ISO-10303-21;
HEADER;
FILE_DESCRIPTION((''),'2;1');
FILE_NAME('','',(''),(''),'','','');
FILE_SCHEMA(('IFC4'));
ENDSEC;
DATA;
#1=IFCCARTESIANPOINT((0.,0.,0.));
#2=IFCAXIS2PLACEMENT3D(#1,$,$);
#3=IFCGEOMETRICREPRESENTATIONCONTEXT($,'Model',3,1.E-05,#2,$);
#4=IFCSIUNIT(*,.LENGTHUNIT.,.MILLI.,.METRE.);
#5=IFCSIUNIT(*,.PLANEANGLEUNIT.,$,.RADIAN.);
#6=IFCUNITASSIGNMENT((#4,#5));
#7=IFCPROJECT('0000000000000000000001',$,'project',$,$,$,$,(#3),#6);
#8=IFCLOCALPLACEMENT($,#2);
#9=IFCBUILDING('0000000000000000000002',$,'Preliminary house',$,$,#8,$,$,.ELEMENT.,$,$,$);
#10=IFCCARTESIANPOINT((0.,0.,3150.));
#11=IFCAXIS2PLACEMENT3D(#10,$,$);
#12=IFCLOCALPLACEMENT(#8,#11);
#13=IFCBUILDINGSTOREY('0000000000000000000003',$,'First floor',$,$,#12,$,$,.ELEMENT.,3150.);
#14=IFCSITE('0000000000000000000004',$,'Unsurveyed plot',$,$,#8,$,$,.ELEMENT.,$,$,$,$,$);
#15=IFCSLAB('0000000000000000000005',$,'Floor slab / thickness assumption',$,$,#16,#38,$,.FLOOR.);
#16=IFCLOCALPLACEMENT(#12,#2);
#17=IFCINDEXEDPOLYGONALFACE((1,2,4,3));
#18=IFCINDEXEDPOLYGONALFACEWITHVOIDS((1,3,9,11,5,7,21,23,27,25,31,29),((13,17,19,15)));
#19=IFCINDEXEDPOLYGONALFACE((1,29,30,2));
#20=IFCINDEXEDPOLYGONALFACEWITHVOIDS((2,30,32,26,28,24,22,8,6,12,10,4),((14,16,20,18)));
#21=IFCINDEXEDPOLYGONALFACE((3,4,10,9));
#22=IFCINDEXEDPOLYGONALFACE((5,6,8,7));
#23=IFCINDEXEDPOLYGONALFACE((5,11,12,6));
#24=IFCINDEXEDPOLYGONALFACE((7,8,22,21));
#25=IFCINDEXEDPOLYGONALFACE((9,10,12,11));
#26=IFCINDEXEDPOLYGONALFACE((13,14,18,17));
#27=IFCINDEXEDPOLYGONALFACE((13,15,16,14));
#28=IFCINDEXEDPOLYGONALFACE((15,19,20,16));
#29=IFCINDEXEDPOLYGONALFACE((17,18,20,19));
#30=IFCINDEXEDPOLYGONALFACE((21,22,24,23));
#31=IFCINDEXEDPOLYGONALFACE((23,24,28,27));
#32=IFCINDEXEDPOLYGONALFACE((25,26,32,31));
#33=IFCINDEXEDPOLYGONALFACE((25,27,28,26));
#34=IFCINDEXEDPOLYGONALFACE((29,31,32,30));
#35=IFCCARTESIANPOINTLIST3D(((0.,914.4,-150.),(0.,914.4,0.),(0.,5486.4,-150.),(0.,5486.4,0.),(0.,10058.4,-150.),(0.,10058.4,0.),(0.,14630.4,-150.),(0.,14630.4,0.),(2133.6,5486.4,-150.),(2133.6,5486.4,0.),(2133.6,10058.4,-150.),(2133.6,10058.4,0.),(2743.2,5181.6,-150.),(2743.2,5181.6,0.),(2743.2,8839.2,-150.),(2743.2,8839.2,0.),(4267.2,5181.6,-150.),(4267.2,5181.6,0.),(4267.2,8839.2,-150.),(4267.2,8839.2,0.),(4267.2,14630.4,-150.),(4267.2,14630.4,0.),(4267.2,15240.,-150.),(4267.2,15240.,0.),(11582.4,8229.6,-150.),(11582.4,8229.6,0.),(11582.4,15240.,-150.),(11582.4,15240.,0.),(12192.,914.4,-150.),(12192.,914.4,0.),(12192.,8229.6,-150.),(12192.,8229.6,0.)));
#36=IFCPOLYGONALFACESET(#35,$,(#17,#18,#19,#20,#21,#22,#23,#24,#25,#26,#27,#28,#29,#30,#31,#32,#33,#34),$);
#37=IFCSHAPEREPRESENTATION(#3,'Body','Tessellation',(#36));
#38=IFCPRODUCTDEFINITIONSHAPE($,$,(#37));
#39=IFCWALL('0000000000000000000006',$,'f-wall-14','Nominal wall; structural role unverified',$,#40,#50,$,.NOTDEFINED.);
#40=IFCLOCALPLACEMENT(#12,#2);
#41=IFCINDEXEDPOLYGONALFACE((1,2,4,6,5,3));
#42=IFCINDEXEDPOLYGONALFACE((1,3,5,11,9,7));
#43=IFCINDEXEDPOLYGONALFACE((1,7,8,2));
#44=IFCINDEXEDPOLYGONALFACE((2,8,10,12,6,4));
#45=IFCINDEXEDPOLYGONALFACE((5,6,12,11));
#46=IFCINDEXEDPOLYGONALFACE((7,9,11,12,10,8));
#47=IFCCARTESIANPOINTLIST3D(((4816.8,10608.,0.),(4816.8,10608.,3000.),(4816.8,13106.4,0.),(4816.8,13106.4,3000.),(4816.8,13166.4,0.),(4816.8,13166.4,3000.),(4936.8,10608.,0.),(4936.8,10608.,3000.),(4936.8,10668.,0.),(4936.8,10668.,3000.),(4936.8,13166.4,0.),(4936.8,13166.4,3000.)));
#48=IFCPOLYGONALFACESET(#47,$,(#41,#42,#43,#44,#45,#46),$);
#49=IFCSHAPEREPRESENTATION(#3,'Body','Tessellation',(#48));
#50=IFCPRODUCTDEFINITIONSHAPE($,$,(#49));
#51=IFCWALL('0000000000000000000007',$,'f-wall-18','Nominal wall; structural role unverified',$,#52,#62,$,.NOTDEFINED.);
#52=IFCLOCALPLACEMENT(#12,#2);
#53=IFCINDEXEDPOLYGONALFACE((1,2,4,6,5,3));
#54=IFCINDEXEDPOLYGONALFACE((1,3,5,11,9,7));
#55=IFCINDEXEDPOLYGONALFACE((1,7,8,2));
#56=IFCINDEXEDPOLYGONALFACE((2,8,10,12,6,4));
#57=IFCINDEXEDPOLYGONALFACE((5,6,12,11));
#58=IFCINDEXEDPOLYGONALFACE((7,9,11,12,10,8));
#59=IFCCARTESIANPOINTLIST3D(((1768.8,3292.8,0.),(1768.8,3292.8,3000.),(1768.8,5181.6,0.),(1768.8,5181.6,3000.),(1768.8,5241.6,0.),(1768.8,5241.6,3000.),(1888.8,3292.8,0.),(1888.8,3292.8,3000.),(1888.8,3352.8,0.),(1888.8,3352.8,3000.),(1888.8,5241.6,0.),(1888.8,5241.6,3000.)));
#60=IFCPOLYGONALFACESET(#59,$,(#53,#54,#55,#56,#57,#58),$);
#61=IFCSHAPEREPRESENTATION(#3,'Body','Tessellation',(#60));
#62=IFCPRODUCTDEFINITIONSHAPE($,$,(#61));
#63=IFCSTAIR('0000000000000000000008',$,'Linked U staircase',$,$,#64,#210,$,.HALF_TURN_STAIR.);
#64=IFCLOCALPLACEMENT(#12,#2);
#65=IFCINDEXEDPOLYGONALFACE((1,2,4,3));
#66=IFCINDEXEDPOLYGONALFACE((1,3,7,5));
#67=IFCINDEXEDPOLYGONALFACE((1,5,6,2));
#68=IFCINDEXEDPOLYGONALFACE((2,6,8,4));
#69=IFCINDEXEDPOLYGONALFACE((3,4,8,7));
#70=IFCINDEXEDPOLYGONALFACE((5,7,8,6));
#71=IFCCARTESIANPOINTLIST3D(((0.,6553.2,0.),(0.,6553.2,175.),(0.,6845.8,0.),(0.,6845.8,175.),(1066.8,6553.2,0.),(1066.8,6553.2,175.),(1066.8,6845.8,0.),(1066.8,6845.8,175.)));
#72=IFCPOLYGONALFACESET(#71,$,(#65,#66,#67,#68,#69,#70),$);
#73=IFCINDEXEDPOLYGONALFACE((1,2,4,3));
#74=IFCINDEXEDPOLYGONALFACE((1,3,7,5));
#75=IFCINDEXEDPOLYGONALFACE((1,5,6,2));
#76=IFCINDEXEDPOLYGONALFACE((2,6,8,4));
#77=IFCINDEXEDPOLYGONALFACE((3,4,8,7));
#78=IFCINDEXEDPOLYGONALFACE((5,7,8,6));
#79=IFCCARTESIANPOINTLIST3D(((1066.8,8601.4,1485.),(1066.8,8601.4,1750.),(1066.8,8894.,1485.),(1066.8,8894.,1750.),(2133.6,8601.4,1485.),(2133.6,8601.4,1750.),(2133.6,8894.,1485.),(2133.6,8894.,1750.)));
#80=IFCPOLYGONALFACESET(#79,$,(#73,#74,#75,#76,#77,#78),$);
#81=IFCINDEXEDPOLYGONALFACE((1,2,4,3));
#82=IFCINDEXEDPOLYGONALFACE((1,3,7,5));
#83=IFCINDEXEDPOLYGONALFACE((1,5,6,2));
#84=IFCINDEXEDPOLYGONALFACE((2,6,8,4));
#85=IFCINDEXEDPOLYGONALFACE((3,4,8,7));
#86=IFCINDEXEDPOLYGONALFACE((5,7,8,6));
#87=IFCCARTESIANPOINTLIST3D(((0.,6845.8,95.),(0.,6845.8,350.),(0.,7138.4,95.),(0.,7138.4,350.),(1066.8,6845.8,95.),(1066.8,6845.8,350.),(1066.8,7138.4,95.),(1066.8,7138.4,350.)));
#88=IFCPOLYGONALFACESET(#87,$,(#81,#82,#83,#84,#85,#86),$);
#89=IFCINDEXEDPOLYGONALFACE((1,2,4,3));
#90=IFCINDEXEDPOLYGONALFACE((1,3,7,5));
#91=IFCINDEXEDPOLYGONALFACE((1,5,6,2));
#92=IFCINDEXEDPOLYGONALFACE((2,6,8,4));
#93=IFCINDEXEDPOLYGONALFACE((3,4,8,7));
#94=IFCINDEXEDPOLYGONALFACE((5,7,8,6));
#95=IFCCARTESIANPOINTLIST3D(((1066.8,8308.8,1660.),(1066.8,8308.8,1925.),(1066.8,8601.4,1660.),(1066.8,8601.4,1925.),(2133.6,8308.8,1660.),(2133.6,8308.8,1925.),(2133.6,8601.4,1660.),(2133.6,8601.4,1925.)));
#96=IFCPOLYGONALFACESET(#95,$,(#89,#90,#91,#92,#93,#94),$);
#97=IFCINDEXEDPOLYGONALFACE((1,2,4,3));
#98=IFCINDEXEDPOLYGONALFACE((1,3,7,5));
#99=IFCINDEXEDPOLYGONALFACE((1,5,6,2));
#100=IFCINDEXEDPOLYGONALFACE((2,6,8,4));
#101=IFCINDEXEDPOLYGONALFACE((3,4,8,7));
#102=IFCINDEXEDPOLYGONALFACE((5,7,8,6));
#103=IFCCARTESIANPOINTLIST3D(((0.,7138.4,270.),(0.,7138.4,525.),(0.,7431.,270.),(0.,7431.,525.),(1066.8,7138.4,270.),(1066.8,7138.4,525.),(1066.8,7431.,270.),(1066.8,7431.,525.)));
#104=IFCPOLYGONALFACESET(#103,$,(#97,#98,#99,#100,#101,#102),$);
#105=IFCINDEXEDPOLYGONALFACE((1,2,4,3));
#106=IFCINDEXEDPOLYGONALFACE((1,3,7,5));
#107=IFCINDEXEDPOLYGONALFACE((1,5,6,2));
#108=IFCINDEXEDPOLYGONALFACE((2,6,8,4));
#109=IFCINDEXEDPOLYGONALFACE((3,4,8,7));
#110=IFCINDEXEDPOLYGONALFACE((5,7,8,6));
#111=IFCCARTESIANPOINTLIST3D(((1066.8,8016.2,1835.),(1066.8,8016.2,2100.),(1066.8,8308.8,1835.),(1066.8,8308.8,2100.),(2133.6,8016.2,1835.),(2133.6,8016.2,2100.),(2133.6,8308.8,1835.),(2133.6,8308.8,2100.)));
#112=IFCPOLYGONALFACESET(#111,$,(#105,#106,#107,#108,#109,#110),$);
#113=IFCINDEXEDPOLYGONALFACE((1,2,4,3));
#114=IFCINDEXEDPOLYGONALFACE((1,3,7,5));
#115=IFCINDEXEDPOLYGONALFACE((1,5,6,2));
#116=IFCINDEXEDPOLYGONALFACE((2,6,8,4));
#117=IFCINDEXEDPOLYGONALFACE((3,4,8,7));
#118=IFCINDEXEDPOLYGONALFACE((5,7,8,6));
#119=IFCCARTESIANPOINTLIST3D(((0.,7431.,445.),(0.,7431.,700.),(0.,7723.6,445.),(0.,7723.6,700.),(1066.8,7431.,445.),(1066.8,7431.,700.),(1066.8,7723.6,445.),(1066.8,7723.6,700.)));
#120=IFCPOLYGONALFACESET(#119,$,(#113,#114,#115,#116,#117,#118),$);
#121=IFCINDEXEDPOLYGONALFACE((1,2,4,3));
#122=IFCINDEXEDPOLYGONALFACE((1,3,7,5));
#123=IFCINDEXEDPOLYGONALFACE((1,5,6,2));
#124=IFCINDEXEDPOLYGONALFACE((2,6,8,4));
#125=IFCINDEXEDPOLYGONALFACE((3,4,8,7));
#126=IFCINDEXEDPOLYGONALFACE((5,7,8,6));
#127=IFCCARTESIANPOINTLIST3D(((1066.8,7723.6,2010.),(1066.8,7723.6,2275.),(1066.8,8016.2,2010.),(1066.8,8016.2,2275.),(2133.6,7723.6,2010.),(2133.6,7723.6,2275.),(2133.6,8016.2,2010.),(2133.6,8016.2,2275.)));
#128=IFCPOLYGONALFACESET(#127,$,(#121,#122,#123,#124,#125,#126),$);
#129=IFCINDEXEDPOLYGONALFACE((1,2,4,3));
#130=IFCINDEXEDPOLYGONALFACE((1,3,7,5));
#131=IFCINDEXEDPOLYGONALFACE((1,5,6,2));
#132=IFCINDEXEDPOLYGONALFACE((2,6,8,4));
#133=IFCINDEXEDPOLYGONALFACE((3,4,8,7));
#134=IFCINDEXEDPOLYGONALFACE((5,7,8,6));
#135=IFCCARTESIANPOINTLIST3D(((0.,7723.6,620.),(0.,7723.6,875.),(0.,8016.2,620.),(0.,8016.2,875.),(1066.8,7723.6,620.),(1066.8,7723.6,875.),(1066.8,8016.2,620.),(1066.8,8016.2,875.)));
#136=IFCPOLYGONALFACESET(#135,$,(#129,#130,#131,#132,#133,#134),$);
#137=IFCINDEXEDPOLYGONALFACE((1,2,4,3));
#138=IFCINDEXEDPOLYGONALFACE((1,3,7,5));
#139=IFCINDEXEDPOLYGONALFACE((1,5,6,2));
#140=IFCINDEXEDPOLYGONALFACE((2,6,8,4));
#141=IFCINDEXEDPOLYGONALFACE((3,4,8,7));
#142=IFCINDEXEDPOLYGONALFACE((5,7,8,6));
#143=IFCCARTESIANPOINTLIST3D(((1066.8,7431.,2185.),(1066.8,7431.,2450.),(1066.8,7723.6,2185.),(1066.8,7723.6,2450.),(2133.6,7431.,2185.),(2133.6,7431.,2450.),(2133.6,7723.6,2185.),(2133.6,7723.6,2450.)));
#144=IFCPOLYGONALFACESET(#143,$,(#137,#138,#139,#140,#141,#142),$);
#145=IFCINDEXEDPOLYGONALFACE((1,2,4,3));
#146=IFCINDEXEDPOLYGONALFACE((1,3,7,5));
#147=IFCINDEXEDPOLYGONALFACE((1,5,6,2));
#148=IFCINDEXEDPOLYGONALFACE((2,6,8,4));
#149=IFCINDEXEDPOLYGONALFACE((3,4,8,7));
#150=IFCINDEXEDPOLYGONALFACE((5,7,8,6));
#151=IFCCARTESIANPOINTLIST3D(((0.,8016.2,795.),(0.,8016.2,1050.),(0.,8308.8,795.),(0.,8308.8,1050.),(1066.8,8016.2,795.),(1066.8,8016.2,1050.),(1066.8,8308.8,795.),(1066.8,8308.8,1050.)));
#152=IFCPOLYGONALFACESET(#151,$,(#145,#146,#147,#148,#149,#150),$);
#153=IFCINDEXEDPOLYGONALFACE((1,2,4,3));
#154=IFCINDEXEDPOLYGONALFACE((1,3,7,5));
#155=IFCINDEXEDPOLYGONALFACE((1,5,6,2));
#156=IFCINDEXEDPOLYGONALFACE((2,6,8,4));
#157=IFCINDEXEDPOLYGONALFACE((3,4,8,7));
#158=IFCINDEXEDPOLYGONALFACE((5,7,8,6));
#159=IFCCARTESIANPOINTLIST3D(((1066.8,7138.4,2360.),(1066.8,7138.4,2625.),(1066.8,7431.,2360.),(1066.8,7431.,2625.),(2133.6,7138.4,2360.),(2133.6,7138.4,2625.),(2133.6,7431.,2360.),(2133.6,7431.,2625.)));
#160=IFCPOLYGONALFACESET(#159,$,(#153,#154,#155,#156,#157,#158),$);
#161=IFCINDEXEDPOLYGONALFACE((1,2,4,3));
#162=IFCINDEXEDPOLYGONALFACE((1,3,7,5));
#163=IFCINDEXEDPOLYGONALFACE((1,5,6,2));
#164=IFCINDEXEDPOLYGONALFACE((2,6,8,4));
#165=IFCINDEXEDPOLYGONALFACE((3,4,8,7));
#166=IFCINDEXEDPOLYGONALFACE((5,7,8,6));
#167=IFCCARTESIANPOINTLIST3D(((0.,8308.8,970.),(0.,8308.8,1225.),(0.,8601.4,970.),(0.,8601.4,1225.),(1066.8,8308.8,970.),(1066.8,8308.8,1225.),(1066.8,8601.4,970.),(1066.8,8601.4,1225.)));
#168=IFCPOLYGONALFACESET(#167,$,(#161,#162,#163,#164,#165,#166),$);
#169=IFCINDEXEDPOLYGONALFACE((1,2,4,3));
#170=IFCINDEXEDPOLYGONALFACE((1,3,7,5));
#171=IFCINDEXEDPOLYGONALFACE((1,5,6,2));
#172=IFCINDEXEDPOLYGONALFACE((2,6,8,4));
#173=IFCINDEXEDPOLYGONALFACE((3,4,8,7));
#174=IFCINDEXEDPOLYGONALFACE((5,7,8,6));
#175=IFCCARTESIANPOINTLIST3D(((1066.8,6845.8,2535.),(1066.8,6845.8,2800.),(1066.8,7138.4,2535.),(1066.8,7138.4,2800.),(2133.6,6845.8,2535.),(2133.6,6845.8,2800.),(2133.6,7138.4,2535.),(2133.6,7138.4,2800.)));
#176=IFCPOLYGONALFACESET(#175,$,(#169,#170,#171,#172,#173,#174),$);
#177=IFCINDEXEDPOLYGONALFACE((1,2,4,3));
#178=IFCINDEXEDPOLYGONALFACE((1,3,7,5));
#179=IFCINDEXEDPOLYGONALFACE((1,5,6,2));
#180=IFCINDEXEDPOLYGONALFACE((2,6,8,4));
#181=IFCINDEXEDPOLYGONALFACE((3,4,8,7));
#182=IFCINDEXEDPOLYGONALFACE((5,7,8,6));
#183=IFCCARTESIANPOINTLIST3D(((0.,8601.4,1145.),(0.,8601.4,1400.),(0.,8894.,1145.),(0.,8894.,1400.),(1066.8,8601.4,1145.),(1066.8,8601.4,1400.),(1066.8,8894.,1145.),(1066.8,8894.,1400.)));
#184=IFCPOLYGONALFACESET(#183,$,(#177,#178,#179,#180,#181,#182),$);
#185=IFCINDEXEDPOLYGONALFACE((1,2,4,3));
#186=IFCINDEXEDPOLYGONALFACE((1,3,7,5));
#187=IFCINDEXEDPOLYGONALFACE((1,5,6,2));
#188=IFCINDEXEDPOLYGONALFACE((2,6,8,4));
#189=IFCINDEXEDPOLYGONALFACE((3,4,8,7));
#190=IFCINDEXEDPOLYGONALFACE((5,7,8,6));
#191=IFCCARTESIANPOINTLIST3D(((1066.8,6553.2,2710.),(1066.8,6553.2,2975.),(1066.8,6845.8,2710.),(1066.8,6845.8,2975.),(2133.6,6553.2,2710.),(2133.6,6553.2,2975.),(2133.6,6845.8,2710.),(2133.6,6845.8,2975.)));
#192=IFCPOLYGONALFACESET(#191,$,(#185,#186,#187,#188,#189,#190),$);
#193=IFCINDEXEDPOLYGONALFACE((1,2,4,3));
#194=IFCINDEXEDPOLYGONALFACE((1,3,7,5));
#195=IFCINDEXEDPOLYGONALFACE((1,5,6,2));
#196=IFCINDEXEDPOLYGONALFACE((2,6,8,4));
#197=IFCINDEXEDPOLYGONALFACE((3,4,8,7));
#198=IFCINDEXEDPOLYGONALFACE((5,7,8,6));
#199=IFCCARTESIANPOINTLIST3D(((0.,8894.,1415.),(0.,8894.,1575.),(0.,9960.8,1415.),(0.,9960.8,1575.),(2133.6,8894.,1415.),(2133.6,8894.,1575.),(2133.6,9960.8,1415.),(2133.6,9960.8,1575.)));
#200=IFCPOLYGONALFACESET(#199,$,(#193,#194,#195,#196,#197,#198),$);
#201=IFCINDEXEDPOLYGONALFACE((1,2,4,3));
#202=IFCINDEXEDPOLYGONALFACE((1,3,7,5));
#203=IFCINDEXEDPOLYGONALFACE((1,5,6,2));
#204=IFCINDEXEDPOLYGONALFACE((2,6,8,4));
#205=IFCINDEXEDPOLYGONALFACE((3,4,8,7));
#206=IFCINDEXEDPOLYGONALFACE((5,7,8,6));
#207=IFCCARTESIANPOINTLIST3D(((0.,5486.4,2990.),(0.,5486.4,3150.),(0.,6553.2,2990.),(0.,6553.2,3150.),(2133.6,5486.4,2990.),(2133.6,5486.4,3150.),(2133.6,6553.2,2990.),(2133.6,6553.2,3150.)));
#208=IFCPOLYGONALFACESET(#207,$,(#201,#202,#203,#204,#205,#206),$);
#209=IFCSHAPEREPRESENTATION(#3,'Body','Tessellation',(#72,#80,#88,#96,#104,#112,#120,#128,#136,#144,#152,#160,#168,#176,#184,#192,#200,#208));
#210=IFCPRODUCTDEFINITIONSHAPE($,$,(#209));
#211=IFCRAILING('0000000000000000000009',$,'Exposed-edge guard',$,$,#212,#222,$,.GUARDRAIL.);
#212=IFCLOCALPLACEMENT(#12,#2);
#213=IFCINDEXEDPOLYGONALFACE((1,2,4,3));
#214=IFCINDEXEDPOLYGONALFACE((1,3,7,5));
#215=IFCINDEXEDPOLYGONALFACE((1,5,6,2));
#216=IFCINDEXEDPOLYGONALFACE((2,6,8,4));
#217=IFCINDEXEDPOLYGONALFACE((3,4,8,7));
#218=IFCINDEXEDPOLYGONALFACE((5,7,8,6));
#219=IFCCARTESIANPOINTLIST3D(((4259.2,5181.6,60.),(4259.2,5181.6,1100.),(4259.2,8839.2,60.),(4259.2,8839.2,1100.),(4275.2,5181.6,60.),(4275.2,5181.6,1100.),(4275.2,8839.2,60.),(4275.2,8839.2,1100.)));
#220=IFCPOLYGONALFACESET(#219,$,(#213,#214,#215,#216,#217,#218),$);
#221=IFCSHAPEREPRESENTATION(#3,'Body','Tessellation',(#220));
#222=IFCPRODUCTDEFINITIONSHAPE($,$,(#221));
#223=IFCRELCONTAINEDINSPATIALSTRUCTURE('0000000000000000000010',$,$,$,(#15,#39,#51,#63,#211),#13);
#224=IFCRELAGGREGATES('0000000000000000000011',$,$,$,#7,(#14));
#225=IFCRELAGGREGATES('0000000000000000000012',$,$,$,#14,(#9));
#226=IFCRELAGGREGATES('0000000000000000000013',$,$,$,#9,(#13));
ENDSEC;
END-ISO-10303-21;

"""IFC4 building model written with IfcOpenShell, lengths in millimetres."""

from ifc_helpers import new_model, si_unit, frame, origin, place, context, project, spatial, polyline, outline, extrude, element, save


model = new_model("IFC4")

# Units and contexts
model_context = context("Model", 3, precision=1e-05, world=origin())
ifc_project = project(units=[si_unit("LENGTHUNIT", "METRE", prefix="MILLI"), si_unit("PLANEANGLEUNIT", "RADIAN")], contexts=[model_context])

# Site, building, storey
placement_1 = place(None, origin())
site = spatial("IfcSite", under=ifc_project, at=placement_1, Name="Unsurveyed plot", CompositionType="ELEMENT")
building = spatial("IfcBuilding", under=site, at=placement_1, Name="Preliminary house", CompositionType="ELEMENT")
placement_2 = place(placement_1, frame((0.0, 0.0, 3150.0)))
storey = spatial("IfcBuildingStorey", under=building, at=placement_2, Name="First floor", CompositionType="ELEMENT", Elevation=3150.0)

# Slab
element("IfcSlab", 1, at=placement_2, inside=storey, Name="Floor slab / thickness assumption", PredefinedType="FLOOR", context=model_context, shape_type="SweptSolid", body=[
    extrude(outline(polyline([(0.0, 914.4), (0.0, 5486.4), (2133.6, 5486.4), (2133.6, 10058.4), (0.0, 10058.4), (0.0, 14630.4), (4267.2, 14630.4), (4267.2, 15240.0), (11582.4, 15240.0), (11582.4, 8229.6), (12192.0, 8229.6), (12192.0, 914.4), (0.0, 914.4)]), holes=[polyline([(4267.2, 5181.6), (4267.2, 8839.2), (2743.2, 8839.2), (2743.2, 5181.6), (4267.2, 5181.6)])]), frame((0.0, 0.0, -150.0)), (0.0, 0.0, 1.0), 150.0),
])

# Wall
element("IfcWall", 2, at=placement_2, inside=storey, Name="f-wall-14", Description="Nominal wall; structural role unverified", PredefinedType="NOTDEFINED", context=model_context, shape_type="SweptSolid", body=[
    extrude(outline(polyline([(4816.8, 13106.4), (4816.8, 13166.4), (4936.8, 13166.4), (4936.8, 10668.0), (4936.8, 10608.0), (4816.8, 10608.0), (4816.8, 13106.4)])), origin(), (0.0, 0.0, 1.0), 3000.0),
])

# Wall
element("IfcWall", 3, at=placement_2, inside=storey, Name="f-wall-18", Description="Nominal wall; structural role unverified", PredefinedType="NOTDEFINED", context=model_context, shape_type="SweptSolid", body=[
    extrude(outline(polyline([(1768.8, 5181.6), (1768.8, 5241.6), (1888.8, 5241.6), (1888.8, 3352.8), (1888.8, 3292.8), (1768.8, 3292.8), (1768.8, 5181.6)])), origin(), (0.0, 0.0, 1.0), 3000.0),
])

# Stair
element("IfcStair", 4, at=placement_2, inside=storey, Name="Linked U staircase", PredefinedType="HALF_TURN_STAIR", context=model_context, shape_type="SweptSolid", body=[
    extrude(outline(polyline([(1066.8, 6553.2), (1066.8, 6845.8), (0.0, 6845.8), (0.0, 6553.2), (1066.8, 6553.2)])), origin(), (0.0, 0.0, 1.0), 175.0),
    extrude(outline(polyline([(2133.6, 8601.4), (2133.6, 8894.0), (1066.8, 8894.0), (1066.8, 8601.4), (2133.6, 8601.4)])), frame((0.0, 0.0, 1485.0)), (0.0, 0.0, 1.0), 265.0),
    extrude(outline(polyline([(1066.8, 6845.8), (1066.8, 7138.4), (0.0, 7138.4), (0.0, 6845.8), (1066.8, 6845.8)])), frame((0.0, 0.0, 95.0)), (0.0, 0.0, 1.0), 255.0),
    extrude(outline(polyline([(2133.6, 8308.8), (2133.6, 8601.4), (1066.8, 8601.4), (1066.8, 8308.8), (2133.6, 8308.8)])), frame((0.0, 0.0, 1660.0)), (0.0, 0.0, 1.0), 265.0),
    extrude(outline(polyline([(1066.8, 7138.4), (1066.8, 7431.0), (0.0, 7431.0), (0.0, 7138.4), (1066.8, 7138.4)])), frame((0.0, 0.0, 270.0)), (0.0, 0.0, 1.0), 255.0),
    extrude(outline(polyline([(2133.6, 8016.2), (2133.6, 8308.8), (1066.8, 8308.8), (1066.8, 8016.2), (2133.6, 8016.2)])), frame((0.0, 0.0, 1835.0)), (0.0, 0.0, 1.0), 265.0),
    extrude(outline(polyline([(1066.8, 7431.0), (1066.8, 7723.6), (0.0, 7723.6), (0.0, 7431.0), (1066.8, 7431.0)])), frame((0.0, 0.0, 445.0)), (0.0, 0.0, 1.0), 255.0),
    extrude(outline(polyline([(2133.6, 7723.6), (2133.6, 8016.2), (1066.8, 8016.2), (1066.8, 7723.6), (2133.6, 7723.6)])), frame((0.0, 0.0, 2010.0)), (0.0, 0.0, 1.0), 265.0),
    extrude(outline(polyline([(1066.8, 7723.6), (1066.8, 8016.2), (0.0, 8016.2), (0.0, 7723.6), (1066.8, 7723.6)])), frame((0.0, 0.0, 620.0)), (0.0, 0.0, 1.0), 255.0),
    extrude(outline(polyline([(2133.6, 7431.0), (2133.6, 7723.6), (1066.8, 7723.6), (1066.8, 7431.0), (2133.6, 7431.0)])), frame((0.0, 0.0, 2185.0)), (0.0, 0.0, 1.0), 265.0),
    extrude(outline(polyline([(1066.8, 8016.2), (1066.8, 8308.8), (0.0, 8308.8), (0.0, 8016.2), (1066.8, 8016.2)])), frame((0.0, 0.0, 795.0)), (0.0, 0.0, 1.0), 255.0),
    extrude(outline(polyline([(2133.6, 7138.4), (2133.6, 7431.0), (1066.8, 7431.0), (1066.8, 7138.4), (2133.6, 7138.4)])), frame((0.0, 0.0, 2360.0)), (0.0, 0.0, 1.0), 265.0),
    extrude(outline(polyline([(1066.8, 8308.8), (1066.8, 8601.4), (0.0, 8601.4), (0.0, 8308.8), (1066.8, 8308.8)])), frame((0.0, 0.0, 970.0)), (0.0, 0.0, 1.0), 255.0),
    extrude(outline(polyline([(2133.6, 6845.8), (2133.6, 7138.4), (1066.8, 7138.4), (1066.8, 6845.8), (2133.6, 6845.8)])), frame((0.0, 0.0, 2535.0)), (0.0, 0.0, 1.0), 265.0),
    extrude(outline(polyline([(1066.8, 8601.4), (1066.8, 8894.0), (0.0, 8894.0), (0.0, 8601.4), (1066.8, 8601.4)])), frame((0.0, 0.0, 1145.0)), (0.0, 0.0, 1.0), 255.0),
    extrude(outline(polyline([(2133.6, 6553.2), (2133.6, 6845.8), (1066.8, 6845.8), (1066.8, 6553.2), (2133.6, 6553.2)])), frame((0.0, 0.0, 2710.0)), (0.0, 0.0, 1.0), 265.0),
    extrude(outline(polyline([(2133.6, 8894.0), (2133.6, 9960.8), (0.0, 9960.8), (0.0, 8894.0), (2133.6, 8894.0)])), frame((0.0, 0.0, 1415.0)), (0.0, 0.0, 1.0), 160.0),
    extrude(outline(polyline([(2133.6, 5486.4), (2133.6, 6553.2), (0.0, 6553.2), (0.0, 5486.4), (2133.6, 5486.4)])), frame((0.0, 0.0, 2990.0)), (0.0, 0.0, 1.0), 160.0),
])

# Railing
element("IfcRailing", 5, at=placement_2, inside=storey, Name="Exposed-edge guard", PredefinedType="GUARDRAIL", context=model_context, shape_type="SweptSolid", body=[
    extrude(outline(polyline([(4275.2, 5181.6), (4259.2, 5181.6), (4259.2, 8839.2), (4275.2, 8839.2), (4275.2, 5181.6)])), frame((0.0, 0.0, 60.0)), (0.0, 0.0, 1.0), 1040.0),
])

save(model, "model.ifc")
